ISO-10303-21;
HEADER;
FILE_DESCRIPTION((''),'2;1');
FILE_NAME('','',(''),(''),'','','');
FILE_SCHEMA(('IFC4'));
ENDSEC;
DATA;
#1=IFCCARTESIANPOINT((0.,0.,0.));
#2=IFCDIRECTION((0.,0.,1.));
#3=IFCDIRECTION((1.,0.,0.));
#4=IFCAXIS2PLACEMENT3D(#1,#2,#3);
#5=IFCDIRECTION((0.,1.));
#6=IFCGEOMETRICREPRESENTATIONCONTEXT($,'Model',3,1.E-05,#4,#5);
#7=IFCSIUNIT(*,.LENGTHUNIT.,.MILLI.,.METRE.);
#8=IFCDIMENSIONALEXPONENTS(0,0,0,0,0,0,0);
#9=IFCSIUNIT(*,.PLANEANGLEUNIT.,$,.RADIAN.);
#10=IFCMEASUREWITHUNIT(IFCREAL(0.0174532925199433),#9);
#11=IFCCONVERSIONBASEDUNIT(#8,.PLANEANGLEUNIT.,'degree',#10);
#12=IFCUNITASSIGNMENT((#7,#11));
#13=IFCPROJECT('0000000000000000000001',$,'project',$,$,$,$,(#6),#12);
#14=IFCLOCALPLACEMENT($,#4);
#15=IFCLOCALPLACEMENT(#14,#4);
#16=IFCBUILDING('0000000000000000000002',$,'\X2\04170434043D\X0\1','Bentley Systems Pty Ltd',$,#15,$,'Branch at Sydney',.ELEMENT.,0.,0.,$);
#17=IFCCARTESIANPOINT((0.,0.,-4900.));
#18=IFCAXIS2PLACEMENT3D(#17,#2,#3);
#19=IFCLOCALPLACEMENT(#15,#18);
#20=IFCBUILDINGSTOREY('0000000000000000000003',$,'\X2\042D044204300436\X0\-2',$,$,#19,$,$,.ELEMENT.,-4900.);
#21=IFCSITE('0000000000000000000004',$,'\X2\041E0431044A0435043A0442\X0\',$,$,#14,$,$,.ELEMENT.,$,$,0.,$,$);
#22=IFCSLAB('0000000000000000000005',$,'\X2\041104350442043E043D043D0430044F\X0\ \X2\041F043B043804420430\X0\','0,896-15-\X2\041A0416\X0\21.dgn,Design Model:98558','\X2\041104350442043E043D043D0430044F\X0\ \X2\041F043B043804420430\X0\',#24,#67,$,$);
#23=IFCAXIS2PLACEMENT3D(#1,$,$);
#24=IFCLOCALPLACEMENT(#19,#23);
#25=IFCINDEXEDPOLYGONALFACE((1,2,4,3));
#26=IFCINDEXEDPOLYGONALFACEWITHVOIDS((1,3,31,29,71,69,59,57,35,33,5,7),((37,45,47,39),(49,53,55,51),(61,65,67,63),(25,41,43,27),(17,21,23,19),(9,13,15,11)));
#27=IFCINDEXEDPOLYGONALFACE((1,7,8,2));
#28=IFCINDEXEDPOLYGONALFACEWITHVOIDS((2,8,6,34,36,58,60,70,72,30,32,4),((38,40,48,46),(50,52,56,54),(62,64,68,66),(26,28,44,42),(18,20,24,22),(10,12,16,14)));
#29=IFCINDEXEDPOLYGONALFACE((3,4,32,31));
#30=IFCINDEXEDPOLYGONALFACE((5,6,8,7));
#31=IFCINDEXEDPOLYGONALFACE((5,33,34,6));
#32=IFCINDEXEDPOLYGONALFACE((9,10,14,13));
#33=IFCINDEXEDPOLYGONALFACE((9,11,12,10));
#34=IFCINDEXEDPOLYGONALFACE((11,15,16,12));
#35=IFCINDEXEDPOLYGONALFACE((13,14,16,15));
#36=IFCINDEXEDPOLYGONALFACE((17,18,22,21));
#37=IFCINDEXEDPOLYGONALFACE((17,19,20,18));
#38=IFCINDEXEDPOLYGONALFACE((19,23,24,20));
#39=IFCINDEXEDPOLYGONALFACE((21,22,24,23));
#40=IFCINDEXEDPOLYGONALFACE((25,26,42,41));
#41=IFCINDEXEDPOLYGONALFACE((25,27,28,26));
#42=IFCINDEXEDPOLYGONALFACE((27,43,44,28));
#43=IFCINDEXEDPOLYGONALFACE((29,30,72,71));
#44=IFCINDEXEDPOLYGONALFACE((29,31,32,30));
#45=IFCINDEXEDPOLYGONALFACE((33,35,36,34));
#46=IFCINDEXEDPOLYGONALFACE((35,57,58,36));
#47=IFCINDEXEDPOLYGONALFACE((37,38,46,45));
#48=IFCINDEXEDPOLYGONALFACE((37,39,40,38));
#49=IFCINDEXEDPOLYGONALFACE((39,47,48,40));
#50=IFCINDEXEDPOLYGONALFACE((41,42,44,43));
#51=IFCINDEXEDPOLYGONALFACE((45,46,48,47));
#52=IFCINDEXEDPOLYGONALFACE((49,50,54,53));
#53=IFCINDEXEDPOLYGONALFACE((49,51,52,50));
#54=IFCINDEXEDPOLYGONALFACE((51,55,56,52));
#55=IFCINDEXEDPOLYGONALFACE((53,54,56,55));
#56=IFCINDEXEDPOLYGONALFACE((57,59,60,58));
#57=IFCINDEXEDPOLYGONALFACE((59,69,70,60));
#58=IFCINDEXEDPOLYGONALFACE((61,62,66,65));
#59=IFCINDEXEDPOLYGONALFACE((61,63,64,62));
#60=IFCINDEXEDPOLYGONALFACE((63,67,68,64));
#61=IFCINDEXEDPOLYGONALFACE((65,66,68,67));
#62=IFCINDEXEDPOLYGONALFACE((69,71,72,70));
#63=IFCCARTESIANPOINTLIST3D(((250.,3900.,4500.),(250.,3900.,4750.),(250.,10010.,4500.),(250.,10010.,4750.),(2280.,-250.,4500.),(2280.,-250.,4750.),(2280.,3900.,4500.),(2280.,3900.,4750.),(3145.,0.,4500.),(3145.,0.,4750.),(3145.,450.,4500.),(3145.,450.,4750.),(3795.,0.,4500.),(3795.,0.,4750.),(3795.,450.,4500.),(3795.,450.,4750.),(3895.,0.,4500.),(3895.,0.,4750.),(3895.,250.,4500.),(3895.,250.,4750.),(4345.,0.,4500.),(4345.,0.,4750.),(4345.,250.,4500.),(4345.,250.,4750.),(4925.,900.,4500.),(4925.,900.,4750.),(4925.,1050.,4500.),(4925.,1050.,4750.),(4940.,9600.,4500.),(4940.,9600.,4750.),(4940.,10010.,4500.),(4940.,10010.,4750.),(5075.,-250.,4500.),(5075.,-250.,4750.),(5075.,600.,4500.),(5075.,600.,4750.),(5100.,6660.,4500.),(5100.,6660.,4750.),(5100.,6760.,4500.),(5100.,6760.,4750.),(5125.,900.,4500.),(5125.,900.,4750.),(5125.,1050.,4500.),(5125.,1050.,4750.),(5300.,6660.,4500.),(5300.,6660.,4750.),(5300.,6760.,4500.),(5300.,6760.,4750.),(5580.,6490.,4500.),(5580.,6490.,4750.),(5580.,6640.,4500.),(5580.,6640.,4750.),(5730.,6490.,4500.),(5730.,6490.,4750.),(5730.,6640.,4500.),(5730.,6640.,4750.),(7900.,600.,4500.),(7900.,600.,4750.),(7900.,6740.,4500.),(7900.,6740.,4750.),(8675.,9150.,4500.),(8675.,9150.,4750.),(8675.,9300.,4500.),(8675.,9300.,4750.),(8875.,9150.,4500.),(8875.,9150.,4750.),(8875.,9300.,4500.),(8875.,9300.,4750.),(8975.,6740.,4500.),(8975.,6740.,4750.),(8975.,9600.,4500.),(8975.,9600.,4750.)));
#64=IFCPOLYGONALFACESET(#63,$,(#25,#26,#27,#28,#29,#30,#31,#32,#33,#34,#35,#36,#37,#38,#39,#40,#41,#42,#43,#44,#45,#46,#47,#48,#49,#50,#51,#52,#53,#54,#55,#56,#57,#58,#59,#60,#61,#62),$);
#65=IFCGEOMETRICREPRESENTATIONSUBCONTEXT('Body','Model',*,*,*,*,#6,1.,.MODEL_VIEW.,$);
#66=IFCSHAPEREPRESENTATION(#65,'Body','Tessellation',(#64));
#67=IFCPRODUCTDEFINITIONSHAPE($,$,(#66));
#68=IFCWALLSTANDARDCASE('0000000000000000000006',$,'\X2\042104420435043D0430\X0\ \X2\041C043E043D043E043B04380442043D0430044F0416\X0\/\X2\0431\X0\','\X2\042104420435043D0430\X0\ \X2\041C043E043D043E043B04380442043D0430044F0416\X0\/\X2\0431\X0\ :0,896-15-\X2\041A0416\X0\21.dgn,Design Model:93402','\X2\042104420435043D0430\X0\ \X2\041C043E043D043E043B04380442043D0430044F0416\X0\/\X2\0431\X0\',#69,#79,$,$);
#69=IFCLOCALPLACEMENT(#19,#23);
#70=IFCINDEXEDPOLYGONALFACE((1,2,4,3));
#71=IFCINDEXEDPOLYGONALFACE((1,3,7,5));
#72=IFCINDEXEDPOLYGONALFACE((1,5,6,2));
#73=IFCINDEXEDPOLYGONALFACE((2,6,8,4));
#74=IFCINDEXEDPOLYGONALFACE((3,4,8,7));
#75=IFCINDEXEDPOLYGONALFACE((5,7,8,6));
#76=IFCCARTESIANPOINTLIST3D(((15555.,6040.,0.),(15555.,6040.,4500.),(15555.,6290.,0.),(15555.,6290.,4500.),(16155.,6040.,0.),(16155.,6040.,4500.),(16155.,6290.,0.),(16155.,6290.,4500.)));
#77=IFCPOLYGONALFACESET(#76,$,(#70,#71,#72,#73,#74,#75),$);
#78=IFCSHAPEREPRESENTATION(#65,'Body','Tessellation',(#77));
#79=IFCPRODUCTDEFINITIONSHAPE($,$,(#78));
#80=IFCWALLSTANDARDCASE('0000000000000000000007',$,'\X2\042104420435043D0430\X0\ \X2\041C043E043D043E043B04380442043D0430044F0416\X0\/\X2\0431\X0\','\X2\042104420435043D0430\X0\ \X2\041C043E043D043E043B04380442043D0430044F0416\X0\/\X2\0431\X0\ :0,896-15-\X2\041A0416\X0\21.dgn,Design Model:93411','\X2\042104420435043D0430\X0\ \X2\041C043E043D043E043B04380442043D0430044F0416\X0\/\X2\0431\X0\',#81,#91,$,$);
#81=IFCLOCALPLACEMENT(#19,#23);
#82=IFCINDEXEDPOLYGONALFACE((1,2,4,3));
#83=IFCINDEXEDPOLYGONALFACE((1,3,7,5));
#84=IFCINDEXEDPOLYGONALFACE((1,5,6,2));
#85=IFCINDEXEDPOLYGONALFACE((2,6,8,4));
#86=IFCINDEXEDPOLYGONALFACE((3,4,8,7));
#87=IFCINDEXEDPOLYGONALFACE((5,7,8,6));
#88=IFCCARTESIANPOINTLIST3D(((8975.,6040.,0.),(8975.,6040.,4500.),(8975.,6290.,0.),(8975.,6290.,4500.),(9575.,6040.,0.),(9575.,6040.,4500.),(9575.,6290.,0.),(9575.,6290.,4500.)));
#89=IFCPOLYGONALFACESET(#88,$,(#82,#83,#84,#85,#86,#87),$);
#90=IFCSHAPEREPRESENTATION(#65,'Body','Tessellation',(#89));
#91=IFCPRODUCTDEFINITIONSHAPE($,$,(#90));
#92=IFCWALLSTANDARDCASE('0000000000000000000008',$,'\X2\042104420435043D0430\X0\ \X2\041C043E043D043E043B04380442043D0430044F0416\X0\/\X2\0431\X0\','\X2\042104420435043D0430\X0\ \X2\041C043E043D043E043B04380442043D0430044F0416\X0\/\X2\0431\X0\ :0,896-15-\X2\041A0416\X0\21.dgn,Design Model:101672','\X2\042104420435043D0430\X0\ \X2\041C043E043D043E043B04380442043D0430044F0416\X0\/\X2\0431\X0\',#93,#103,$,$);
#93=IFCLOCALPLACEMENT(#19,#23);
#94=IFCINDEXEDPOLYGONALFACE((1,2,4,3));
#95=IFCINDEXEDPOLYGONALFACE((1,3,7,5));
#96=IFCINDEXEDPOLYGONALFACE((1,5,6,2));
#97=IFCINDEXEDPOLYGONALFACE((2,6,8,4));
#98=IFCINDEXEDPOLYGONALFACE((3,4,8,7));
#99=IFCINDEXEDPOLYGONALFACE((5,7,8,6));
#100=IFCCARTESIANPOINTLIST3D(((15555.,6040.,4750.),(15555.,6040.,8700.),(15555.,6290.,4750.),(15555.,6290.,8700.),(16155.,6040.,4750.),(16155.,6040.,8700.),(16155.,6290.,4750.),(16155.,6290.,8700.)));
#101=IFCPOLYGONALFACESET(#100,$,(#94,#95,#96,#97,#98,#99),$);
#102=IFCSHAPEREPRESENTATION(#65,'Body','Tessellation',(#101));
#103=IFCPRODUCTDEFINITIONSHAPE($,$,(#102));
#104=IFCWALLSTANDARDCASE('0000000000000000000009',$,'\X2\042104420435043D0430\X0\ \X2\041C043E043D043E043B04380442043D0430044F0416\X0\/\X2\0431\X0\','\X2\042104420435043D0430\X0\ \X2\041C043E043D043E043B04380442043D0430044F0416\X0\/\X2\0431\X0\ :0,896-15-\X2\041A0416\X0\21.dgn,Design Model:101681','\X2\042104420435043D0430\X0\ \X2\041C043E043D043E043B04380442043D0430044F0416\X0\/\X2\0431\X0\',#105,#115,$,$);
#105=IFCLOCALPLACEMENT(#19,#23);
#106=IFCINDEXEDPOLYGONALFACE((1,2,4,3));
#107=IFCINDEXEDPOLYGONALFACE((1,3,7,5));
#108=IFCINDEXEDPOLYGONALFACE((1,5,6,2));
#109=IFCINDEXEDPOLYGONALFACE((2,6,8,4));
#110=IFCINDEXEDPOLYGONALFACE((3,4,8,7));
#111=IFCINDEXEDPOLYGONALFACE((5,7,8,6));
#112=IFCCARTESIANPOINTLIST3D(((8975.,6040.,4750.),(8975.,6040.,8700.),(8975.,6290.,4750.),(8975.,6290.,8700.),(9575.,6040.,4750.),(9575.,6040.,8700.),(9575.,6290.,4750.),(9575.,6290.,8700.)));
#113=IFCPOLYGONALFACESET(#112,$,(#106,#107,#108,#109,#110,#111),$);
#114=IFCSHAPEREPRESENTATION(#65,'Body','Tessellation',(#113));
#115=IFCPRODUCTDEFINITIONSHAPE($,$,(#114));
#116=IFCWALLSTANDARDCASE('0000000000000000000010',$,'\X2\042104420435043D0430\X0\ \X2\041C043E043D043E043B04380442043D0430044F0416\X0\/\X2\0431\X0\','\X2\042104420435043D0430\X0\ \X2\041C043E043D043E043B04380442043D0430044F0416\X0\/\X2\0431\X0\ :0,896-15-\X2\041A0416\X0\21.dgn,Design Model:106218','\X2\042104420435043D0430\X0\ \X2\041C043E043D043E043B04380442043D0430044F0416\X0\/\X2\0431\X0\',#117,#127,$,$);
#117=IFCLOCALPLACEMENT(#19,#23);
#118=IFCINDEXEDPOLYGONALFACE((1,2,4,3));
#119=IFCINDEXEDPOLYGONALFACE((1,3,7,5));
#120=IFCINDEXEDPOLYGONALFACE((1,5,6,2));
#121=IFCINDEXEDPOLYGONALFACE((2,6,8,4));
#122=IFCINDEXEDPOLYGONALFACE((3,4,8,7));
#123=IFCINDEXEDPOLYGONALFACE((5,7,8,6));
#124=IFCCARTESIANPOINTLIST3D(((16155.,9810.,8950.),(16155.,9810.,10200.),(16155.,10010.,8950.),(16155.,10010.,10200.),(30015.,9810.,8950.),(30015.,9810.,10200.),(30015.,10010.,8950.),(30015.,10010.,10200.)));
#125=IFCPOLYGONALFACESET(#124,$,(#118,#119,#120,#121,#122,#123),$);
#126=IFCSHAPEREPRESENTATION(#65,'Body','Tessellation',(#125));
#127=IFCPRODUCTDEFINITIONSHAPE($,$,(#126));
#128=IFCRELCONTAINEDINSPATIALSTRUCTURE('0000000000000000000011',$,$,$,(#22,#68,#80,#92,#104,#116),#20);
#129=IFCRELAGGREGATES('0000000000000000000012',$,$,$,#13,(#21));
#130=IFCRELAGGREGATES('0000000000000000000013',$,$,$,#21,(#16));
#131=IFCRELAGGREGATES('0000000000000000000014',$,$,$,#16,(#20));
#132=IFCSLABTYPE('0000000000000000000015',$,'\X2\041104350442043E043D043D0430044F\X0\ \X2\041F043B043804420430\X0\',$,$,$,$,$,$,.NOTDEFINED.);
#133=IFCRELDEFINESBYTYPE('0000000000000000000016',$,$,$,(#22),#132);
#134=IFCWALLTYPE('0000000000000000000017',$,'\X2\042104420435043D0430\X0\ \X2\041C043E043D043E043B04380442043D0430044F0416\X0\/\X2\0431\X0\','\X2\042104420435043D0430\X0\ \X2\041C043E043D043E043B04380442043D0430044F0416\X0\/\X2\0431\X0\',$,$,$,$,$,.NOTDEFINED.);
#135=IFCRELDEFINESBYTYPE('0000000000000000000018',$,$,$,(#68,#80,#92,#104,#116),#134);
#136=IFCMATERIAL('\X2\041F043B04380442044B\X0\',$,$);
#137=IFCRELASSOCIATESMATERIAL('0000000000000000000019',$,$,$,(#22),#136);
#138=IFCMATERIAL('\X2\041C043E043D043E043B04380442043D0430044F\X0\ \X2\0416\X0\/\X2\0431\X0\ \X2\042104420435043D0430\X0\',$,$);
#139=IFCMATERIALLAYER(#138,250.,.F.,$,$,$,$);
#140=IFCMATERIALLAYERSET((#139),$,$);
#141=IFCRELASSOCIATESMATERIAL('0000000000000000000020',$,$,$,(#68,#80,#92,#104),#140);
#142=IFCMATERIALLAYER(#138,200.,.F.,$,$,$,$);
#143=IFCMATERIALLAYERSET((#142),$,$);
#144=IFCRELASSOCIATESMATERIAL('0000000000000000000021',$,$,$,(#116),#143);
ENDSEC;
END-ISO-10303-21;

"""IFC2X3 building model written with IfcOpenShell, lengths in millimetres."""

from ifc_helpers import new_model, entity, si_unit, converted_unit, direction, frame, frame_2d, origin_with_axes, place, context, subcontext, project, spatial, polyline, rectangle, outline, extrude, material, layer, layer_set, layer_usage, type_object, element, save


model = new_model("IFC2X3")

# Units and contexts
model_context = context("Model", 3, precision=1e-05, world=origin_with_axes(), true_north=direction((0.0, 1.0)))
body_context = subcontext(model_context, "Body", "Model", "MODEL_VIEW", scale=1.0)
ifc_project = project(units=[si_unit("LENGTHUNIT", "METRE", prefix="MILLI"), converted_unit("PLANEANGLEUNIT", "degree", entity("IfcReal", 0.0174532925199433), si_unit("PLANEANGLEUNIT", "RADIAN"), dimensions=[0, 0, 0, 0, 0, 0, 0])], contexts=[model_context])

# Site, building, storey
site_placement = place(None, origin_with_axes())
site = spatial("IfcSite", under=ifc_project, at=site_placement, Name="Объект", CompositionType="ELEMENT", RefElevation=0.0)
building_placement = place(site_placement, origin_with_axes())
building = spatial("IfcBuilding", under=site, at=building_placement, Name="Здн1", Description="Bentley Systems Pty Ltd", LongName="Branch at Sydney", CompositionType="ELEMENT", ElevationOfRefHeight=0.0, ElevationOfTerrain=0.0)
storey_placement = place(building_placement, frame((0.0, 0.0, -4900.0), z_axis=(0.0, 0.0, 1.0), x_axis=(1.0, 0.0, 0.0)))
storey = spatial("IfcBuildingStorey", under=building, at=storey_placement, Name="Этаж-2", CompositionType="ELEMENT", Elevation=-4900.0)

# Shared definitions
ifc_material_1 = material(Name="Плиты")
slab_type = type_object("IfcSlabType", Name="Бетонная Плита", PredefinedType="NOTDEFINED")

# Slab, openings
slab_1_placement = place(storey_placement, frame((8975.0, 9600.0, 4750.0), z_axis=(0.0, 0.0, -1.0), x_axis=(0.0, -1.0, 0.0)))
slab_1 = element("IfcSlab", 1, at=slab_1_placement, inside=storey, type_object=slab_type, material=ifc_material_1, Name="Бетонная Плита", Description="0,896-15-КЖ21.dgn,Design Model:98558", ObjectType="Бетонная Плита", context=body_context, shape_type="SweptSolid", body=[
    extrude(outline(polyline([(0.0, 0.0), (2860.0, 0.0), (2860.0, 1075.0), (9000.0, 1075.0), (9000.0, 3900.0), (9850.0, 3900.0), (9850.0, 6695.0), (5700.0, 6695.0), (5700.0, 8725.0), (-410.0, 8725.0), (-410.0, 4035.0), (0.0, 4035.0), (0.0, 0.0)])), origin_with_axes(), (0.0, 0.0, 1.0), 250.0),
])
opening_1_placement = place(slab_1_placement, frame((300.0, 100.0, 0.0), z_axis=(0.0, 0.0, 1.0), x_axis=(1.0, 0.0, 0.0)))
element("IfcOpeningElement", 2, at=opening_1_placement, cuts=slab_1, ObjectType="Opening", context=body_context, shape_type="SweptSolid", body=[
    extrude(rectangle(XDim=200.0, YDim=150.0, at=frame_2d((-75.0, 100.0), x_axis=(0.0, 1.0))), frame((0.0, 0.0, 375.0), z_axis=(0.0, 0.0, -1.0), x_axis=(-1.0, 0.0, 0.0)), (0.0, 0.0, 1.0), 750.0),
])
opening_2_placement = place(slab_1_placement, frame((2960.0, 3245.0, 0.0), z_axis=(0.0, 0.0, 1.0), x_axis=(1.0, 0.0, 0.0)))
element("IfcOpeningElement", 3, at=opening_2_placement, cuts=slab_1, ObjectType="Opening", context=body_context, shape_type="SweptSolid", body=[
    extrude(rectangle(XDim=150.0, YDim=150.0, at=frame_2d((-75.0, 75.0), x_axis=(0.0, 1.0))), frame((0.0, 0.0, 375.0), z_axis=(0.0, 0.0, -1.0), x_axis=(-1.0, 0.0, 0.0)), (0.0, 0.0, 1.0), 750.0),
])
opening_3_placement = place(slab_1_placement, frame((2840.0, 3675.0, 0.0), z_axis=(0.0, 0.0, 1.0), x_axis=(1.0, 0.0, 0.0)))
element("IfcOpeningElement", 4, at=opening_3_placement, cuts=slab_1, ObjectType="Opening", context=body_context, shape_type="SweptSolid", body=[
    extrude(rectangle(XDim=200.0, YDim=100.0, at=frame_2d((-50.0, 100.0), x_axis=(0.0, 1.0))), frame((0.0, 0.0, 375.0), z_axis=(0.0, 0.0, -1.0), x_axis=(-1.0, 0.0, 0.0)), (0.0, 0.0, 1.0), 750.0),
])
opening_4_placement = place(slab_1_placement, frame((9150.0, 5180.0, 0.0), z_axis=(0.0, 0.0, 1.0), x_axis=(1.0, 0.0, 0.0)))
element("IfcOpeningElement", 5, at=opening_4_placement, cuts=slab_1, ObjectType="Opening", context=body_context, shape_type="SweptSolid", body=[
    extrude(rectangle(XDim=650.0, YDim=450.0, at=frame_2d((-225.0, 325.0), x_axis=(0.0, 1.0))), frame((0.0, 0.0, 375.0), z_axis=(0.0, 0.0, -1.0), x_axis=(-1.0, 0.0, 0.0)), (0.0, 0.0, 1.0), 750.0),
])
opening_5_placement = place(slab_1_placement, frame((9350.0, 4630.0, 0.0), z_axis=(0.0, 0.0, 1.0), x_axis=(1.0, 0.0, 0.0)))
element("IfcOpeningElement", 6, at=opening_5_placement, cuts=slab_1, ObjectType="Opening", context=body_context, shape_type="SweptSolid", body=[
    extrude(rectangle(XDim=450.0, YDim=250.0, at=frame_2d((-125.0, 225.0), x_axis=(0.0, 1.0))), frame((0.0, 0.0, 375.0), z_axis=(0.0, 0.0, -1.0), x_axis=(-1.0, 0.0, 0.0)), (0.0, 0.0, 1.0), 750.0),
])
opening_6_placement = place(slab_1_placement, frame((8550.0, 3850.0, 0.0), z_axis=(0.0, 0.0, 1.0), x_axis=(1.0, 0.0, 0.0)))
element("IfcOpeningElement", 7, at=opening_6_placement, cuts=slab_1, ObjectType="Opening", context=body_context, shape_type="SweptSolid", body=[
    extrude(rectangle(XDim=200.0, YDim=150.0, at=frame_2d((-75.0, 100.0), x_axis=(0.0, 1.0))), frame((0.0, 0.0, 375.0), z_axis=(0.0, 0.0, -1.0), x_axis=(-1.0, 0.0, 0.0)), (0.0, 0.0, 1.0), 750.0),
])

# Walls
ifc_material_2 = material(Name="Монолитная Ж/б Стена")
ifc_layer_1 = layer(ifc_material_2, 250.0, ventilated=False)
ifc_layer_set_1 = layer_set([ifc_layer_1])
ifc_layer_usage_1 = layer_usage(ifc_layer_set_1, "AXIS2", "POSITIVE", 0.0)
wall_type = type_object("IfcWallType", Name="Стена МонолитнаяЖ/б", Description="Стена МонолитнаяЖ/б", PredefinedType="NOTDEFINED")
for number, where, z_axis, x_axis, name, description in (
    (8, (15555.0, 6040.0, 0.0), (0.0, 0.0, 1.0), (1.0, 0.0, 0.0), "Стена МонолитнаяЖ/б", "Стена МонолитнаяЖ/б :0,896-15-КЖ21.dgn,Design Model:93402"),
    (9, (8975.0, 6040.0, 0.0), (0.0, 0.0, 1.0), (1.0, 0.0, 0.0), "Стена МонолитнаяЖ/б", "Стена МонолитнаяЖ/б :0,896-15-КЖ21.dgn,Design Model:93411"),
):
    element("IfcWallStandardCase", number, at=place(storey_placement, frame(where, z_axis=z_axis, x_axis=x_axis)), inside=storey, type_object=wall_type, material=ifc_layer_usage_1, Name=name, Description=description, ObjectType="Стена МонолитнаяЖ/б", context=body_context, shape_type="SweptSolid", body=[
        extrude(rectangle(XDim=600.0, YDim=250.0, at=frame_2d((300.0, 125.0), x_axis=(1.0, 0.0))), origin_with_axes(), (0.0, 0.0, 1.0), 4500.0),
    ])
for number, where, z_axis, x_axis, name, description in (
    (10, (15555.0, 6040.0, 4750.0), (0.0, 0.0, 1.0), (1.0, 0.0, 0.0), "Стена МонолитнаяЖ/б", "Стена МонолитнаяЖ/б :0,896-15-КЖ21.dgn,Design Model:101672"),
    (11, (8975.0, 6040.0, 4750.0), (0.0, 0.0, 1.0), (1.0, 0.0, 0.0), "Стена МонолитнаяЖ/б", "Стена МонолитнаяЖ/б :0,896-15-КЖ21.dgn,Design Model:101681"),
):
    element("IfcWallStandardCase", number, at=place(storey_placement, frame(where, z_axis=z_axis, x_axis=x_axis)), inside=storey, type_object=wall_type, material=ifc_layer_usage_1, Name=name, Description=description, ObjectType="Стена МонолитнаяЖ/б", context=body_context, shape_type="SweptSolid", body=[
        extrude(rectangle(XDim=600.0, YDim=250.0, at=frame_2d((300.0, 125.0), x_axis=(1.0, 0.0))), origin_with_axes(), (0.0, 0.0, 1.0), 3950.0),
    ])
ifc_layer_2 = layer(ifc_material_2, 200.0, ventilated=False)
ifc_layer_set_2 = layer_set([ifc_layer_2])
ifc_layer_usage_2 = layer_usage(ifc_layer_set_2, "AXIS2", "POSITIVE", 0.0)
wall_placement = place(storey_placement, frame((16155.0, 10010.0, 8950.0), z_axis=(0.0, 0.0, 1.0), x_axis=(1.0, 0.0, 0.0)))
element("IfcWallStandardCase", 12, at=wall_placement, inside=storey, type_object=wall_type, material=ifc_layer_usage_2, Name="Стена МонолитнаяЖ/б", Description="Стена МонолитнаяЖ/б :0,896-15-КЖ21.dgn,Design Model:106218", ObjectType="Стена МонолитнаяЖ/б", context=body_context, shape_type="SweptSolid", body=[
    extrude(rectangle(XDim=13860.0, YDim=200.0, at=frame_2d((6930.0, -100.0), x_axis=(1.0, 0.0))), origin_with_axes(), (0.0, 0.0, 1.0), 1250.0),
])

save(model, "model.ifc")
